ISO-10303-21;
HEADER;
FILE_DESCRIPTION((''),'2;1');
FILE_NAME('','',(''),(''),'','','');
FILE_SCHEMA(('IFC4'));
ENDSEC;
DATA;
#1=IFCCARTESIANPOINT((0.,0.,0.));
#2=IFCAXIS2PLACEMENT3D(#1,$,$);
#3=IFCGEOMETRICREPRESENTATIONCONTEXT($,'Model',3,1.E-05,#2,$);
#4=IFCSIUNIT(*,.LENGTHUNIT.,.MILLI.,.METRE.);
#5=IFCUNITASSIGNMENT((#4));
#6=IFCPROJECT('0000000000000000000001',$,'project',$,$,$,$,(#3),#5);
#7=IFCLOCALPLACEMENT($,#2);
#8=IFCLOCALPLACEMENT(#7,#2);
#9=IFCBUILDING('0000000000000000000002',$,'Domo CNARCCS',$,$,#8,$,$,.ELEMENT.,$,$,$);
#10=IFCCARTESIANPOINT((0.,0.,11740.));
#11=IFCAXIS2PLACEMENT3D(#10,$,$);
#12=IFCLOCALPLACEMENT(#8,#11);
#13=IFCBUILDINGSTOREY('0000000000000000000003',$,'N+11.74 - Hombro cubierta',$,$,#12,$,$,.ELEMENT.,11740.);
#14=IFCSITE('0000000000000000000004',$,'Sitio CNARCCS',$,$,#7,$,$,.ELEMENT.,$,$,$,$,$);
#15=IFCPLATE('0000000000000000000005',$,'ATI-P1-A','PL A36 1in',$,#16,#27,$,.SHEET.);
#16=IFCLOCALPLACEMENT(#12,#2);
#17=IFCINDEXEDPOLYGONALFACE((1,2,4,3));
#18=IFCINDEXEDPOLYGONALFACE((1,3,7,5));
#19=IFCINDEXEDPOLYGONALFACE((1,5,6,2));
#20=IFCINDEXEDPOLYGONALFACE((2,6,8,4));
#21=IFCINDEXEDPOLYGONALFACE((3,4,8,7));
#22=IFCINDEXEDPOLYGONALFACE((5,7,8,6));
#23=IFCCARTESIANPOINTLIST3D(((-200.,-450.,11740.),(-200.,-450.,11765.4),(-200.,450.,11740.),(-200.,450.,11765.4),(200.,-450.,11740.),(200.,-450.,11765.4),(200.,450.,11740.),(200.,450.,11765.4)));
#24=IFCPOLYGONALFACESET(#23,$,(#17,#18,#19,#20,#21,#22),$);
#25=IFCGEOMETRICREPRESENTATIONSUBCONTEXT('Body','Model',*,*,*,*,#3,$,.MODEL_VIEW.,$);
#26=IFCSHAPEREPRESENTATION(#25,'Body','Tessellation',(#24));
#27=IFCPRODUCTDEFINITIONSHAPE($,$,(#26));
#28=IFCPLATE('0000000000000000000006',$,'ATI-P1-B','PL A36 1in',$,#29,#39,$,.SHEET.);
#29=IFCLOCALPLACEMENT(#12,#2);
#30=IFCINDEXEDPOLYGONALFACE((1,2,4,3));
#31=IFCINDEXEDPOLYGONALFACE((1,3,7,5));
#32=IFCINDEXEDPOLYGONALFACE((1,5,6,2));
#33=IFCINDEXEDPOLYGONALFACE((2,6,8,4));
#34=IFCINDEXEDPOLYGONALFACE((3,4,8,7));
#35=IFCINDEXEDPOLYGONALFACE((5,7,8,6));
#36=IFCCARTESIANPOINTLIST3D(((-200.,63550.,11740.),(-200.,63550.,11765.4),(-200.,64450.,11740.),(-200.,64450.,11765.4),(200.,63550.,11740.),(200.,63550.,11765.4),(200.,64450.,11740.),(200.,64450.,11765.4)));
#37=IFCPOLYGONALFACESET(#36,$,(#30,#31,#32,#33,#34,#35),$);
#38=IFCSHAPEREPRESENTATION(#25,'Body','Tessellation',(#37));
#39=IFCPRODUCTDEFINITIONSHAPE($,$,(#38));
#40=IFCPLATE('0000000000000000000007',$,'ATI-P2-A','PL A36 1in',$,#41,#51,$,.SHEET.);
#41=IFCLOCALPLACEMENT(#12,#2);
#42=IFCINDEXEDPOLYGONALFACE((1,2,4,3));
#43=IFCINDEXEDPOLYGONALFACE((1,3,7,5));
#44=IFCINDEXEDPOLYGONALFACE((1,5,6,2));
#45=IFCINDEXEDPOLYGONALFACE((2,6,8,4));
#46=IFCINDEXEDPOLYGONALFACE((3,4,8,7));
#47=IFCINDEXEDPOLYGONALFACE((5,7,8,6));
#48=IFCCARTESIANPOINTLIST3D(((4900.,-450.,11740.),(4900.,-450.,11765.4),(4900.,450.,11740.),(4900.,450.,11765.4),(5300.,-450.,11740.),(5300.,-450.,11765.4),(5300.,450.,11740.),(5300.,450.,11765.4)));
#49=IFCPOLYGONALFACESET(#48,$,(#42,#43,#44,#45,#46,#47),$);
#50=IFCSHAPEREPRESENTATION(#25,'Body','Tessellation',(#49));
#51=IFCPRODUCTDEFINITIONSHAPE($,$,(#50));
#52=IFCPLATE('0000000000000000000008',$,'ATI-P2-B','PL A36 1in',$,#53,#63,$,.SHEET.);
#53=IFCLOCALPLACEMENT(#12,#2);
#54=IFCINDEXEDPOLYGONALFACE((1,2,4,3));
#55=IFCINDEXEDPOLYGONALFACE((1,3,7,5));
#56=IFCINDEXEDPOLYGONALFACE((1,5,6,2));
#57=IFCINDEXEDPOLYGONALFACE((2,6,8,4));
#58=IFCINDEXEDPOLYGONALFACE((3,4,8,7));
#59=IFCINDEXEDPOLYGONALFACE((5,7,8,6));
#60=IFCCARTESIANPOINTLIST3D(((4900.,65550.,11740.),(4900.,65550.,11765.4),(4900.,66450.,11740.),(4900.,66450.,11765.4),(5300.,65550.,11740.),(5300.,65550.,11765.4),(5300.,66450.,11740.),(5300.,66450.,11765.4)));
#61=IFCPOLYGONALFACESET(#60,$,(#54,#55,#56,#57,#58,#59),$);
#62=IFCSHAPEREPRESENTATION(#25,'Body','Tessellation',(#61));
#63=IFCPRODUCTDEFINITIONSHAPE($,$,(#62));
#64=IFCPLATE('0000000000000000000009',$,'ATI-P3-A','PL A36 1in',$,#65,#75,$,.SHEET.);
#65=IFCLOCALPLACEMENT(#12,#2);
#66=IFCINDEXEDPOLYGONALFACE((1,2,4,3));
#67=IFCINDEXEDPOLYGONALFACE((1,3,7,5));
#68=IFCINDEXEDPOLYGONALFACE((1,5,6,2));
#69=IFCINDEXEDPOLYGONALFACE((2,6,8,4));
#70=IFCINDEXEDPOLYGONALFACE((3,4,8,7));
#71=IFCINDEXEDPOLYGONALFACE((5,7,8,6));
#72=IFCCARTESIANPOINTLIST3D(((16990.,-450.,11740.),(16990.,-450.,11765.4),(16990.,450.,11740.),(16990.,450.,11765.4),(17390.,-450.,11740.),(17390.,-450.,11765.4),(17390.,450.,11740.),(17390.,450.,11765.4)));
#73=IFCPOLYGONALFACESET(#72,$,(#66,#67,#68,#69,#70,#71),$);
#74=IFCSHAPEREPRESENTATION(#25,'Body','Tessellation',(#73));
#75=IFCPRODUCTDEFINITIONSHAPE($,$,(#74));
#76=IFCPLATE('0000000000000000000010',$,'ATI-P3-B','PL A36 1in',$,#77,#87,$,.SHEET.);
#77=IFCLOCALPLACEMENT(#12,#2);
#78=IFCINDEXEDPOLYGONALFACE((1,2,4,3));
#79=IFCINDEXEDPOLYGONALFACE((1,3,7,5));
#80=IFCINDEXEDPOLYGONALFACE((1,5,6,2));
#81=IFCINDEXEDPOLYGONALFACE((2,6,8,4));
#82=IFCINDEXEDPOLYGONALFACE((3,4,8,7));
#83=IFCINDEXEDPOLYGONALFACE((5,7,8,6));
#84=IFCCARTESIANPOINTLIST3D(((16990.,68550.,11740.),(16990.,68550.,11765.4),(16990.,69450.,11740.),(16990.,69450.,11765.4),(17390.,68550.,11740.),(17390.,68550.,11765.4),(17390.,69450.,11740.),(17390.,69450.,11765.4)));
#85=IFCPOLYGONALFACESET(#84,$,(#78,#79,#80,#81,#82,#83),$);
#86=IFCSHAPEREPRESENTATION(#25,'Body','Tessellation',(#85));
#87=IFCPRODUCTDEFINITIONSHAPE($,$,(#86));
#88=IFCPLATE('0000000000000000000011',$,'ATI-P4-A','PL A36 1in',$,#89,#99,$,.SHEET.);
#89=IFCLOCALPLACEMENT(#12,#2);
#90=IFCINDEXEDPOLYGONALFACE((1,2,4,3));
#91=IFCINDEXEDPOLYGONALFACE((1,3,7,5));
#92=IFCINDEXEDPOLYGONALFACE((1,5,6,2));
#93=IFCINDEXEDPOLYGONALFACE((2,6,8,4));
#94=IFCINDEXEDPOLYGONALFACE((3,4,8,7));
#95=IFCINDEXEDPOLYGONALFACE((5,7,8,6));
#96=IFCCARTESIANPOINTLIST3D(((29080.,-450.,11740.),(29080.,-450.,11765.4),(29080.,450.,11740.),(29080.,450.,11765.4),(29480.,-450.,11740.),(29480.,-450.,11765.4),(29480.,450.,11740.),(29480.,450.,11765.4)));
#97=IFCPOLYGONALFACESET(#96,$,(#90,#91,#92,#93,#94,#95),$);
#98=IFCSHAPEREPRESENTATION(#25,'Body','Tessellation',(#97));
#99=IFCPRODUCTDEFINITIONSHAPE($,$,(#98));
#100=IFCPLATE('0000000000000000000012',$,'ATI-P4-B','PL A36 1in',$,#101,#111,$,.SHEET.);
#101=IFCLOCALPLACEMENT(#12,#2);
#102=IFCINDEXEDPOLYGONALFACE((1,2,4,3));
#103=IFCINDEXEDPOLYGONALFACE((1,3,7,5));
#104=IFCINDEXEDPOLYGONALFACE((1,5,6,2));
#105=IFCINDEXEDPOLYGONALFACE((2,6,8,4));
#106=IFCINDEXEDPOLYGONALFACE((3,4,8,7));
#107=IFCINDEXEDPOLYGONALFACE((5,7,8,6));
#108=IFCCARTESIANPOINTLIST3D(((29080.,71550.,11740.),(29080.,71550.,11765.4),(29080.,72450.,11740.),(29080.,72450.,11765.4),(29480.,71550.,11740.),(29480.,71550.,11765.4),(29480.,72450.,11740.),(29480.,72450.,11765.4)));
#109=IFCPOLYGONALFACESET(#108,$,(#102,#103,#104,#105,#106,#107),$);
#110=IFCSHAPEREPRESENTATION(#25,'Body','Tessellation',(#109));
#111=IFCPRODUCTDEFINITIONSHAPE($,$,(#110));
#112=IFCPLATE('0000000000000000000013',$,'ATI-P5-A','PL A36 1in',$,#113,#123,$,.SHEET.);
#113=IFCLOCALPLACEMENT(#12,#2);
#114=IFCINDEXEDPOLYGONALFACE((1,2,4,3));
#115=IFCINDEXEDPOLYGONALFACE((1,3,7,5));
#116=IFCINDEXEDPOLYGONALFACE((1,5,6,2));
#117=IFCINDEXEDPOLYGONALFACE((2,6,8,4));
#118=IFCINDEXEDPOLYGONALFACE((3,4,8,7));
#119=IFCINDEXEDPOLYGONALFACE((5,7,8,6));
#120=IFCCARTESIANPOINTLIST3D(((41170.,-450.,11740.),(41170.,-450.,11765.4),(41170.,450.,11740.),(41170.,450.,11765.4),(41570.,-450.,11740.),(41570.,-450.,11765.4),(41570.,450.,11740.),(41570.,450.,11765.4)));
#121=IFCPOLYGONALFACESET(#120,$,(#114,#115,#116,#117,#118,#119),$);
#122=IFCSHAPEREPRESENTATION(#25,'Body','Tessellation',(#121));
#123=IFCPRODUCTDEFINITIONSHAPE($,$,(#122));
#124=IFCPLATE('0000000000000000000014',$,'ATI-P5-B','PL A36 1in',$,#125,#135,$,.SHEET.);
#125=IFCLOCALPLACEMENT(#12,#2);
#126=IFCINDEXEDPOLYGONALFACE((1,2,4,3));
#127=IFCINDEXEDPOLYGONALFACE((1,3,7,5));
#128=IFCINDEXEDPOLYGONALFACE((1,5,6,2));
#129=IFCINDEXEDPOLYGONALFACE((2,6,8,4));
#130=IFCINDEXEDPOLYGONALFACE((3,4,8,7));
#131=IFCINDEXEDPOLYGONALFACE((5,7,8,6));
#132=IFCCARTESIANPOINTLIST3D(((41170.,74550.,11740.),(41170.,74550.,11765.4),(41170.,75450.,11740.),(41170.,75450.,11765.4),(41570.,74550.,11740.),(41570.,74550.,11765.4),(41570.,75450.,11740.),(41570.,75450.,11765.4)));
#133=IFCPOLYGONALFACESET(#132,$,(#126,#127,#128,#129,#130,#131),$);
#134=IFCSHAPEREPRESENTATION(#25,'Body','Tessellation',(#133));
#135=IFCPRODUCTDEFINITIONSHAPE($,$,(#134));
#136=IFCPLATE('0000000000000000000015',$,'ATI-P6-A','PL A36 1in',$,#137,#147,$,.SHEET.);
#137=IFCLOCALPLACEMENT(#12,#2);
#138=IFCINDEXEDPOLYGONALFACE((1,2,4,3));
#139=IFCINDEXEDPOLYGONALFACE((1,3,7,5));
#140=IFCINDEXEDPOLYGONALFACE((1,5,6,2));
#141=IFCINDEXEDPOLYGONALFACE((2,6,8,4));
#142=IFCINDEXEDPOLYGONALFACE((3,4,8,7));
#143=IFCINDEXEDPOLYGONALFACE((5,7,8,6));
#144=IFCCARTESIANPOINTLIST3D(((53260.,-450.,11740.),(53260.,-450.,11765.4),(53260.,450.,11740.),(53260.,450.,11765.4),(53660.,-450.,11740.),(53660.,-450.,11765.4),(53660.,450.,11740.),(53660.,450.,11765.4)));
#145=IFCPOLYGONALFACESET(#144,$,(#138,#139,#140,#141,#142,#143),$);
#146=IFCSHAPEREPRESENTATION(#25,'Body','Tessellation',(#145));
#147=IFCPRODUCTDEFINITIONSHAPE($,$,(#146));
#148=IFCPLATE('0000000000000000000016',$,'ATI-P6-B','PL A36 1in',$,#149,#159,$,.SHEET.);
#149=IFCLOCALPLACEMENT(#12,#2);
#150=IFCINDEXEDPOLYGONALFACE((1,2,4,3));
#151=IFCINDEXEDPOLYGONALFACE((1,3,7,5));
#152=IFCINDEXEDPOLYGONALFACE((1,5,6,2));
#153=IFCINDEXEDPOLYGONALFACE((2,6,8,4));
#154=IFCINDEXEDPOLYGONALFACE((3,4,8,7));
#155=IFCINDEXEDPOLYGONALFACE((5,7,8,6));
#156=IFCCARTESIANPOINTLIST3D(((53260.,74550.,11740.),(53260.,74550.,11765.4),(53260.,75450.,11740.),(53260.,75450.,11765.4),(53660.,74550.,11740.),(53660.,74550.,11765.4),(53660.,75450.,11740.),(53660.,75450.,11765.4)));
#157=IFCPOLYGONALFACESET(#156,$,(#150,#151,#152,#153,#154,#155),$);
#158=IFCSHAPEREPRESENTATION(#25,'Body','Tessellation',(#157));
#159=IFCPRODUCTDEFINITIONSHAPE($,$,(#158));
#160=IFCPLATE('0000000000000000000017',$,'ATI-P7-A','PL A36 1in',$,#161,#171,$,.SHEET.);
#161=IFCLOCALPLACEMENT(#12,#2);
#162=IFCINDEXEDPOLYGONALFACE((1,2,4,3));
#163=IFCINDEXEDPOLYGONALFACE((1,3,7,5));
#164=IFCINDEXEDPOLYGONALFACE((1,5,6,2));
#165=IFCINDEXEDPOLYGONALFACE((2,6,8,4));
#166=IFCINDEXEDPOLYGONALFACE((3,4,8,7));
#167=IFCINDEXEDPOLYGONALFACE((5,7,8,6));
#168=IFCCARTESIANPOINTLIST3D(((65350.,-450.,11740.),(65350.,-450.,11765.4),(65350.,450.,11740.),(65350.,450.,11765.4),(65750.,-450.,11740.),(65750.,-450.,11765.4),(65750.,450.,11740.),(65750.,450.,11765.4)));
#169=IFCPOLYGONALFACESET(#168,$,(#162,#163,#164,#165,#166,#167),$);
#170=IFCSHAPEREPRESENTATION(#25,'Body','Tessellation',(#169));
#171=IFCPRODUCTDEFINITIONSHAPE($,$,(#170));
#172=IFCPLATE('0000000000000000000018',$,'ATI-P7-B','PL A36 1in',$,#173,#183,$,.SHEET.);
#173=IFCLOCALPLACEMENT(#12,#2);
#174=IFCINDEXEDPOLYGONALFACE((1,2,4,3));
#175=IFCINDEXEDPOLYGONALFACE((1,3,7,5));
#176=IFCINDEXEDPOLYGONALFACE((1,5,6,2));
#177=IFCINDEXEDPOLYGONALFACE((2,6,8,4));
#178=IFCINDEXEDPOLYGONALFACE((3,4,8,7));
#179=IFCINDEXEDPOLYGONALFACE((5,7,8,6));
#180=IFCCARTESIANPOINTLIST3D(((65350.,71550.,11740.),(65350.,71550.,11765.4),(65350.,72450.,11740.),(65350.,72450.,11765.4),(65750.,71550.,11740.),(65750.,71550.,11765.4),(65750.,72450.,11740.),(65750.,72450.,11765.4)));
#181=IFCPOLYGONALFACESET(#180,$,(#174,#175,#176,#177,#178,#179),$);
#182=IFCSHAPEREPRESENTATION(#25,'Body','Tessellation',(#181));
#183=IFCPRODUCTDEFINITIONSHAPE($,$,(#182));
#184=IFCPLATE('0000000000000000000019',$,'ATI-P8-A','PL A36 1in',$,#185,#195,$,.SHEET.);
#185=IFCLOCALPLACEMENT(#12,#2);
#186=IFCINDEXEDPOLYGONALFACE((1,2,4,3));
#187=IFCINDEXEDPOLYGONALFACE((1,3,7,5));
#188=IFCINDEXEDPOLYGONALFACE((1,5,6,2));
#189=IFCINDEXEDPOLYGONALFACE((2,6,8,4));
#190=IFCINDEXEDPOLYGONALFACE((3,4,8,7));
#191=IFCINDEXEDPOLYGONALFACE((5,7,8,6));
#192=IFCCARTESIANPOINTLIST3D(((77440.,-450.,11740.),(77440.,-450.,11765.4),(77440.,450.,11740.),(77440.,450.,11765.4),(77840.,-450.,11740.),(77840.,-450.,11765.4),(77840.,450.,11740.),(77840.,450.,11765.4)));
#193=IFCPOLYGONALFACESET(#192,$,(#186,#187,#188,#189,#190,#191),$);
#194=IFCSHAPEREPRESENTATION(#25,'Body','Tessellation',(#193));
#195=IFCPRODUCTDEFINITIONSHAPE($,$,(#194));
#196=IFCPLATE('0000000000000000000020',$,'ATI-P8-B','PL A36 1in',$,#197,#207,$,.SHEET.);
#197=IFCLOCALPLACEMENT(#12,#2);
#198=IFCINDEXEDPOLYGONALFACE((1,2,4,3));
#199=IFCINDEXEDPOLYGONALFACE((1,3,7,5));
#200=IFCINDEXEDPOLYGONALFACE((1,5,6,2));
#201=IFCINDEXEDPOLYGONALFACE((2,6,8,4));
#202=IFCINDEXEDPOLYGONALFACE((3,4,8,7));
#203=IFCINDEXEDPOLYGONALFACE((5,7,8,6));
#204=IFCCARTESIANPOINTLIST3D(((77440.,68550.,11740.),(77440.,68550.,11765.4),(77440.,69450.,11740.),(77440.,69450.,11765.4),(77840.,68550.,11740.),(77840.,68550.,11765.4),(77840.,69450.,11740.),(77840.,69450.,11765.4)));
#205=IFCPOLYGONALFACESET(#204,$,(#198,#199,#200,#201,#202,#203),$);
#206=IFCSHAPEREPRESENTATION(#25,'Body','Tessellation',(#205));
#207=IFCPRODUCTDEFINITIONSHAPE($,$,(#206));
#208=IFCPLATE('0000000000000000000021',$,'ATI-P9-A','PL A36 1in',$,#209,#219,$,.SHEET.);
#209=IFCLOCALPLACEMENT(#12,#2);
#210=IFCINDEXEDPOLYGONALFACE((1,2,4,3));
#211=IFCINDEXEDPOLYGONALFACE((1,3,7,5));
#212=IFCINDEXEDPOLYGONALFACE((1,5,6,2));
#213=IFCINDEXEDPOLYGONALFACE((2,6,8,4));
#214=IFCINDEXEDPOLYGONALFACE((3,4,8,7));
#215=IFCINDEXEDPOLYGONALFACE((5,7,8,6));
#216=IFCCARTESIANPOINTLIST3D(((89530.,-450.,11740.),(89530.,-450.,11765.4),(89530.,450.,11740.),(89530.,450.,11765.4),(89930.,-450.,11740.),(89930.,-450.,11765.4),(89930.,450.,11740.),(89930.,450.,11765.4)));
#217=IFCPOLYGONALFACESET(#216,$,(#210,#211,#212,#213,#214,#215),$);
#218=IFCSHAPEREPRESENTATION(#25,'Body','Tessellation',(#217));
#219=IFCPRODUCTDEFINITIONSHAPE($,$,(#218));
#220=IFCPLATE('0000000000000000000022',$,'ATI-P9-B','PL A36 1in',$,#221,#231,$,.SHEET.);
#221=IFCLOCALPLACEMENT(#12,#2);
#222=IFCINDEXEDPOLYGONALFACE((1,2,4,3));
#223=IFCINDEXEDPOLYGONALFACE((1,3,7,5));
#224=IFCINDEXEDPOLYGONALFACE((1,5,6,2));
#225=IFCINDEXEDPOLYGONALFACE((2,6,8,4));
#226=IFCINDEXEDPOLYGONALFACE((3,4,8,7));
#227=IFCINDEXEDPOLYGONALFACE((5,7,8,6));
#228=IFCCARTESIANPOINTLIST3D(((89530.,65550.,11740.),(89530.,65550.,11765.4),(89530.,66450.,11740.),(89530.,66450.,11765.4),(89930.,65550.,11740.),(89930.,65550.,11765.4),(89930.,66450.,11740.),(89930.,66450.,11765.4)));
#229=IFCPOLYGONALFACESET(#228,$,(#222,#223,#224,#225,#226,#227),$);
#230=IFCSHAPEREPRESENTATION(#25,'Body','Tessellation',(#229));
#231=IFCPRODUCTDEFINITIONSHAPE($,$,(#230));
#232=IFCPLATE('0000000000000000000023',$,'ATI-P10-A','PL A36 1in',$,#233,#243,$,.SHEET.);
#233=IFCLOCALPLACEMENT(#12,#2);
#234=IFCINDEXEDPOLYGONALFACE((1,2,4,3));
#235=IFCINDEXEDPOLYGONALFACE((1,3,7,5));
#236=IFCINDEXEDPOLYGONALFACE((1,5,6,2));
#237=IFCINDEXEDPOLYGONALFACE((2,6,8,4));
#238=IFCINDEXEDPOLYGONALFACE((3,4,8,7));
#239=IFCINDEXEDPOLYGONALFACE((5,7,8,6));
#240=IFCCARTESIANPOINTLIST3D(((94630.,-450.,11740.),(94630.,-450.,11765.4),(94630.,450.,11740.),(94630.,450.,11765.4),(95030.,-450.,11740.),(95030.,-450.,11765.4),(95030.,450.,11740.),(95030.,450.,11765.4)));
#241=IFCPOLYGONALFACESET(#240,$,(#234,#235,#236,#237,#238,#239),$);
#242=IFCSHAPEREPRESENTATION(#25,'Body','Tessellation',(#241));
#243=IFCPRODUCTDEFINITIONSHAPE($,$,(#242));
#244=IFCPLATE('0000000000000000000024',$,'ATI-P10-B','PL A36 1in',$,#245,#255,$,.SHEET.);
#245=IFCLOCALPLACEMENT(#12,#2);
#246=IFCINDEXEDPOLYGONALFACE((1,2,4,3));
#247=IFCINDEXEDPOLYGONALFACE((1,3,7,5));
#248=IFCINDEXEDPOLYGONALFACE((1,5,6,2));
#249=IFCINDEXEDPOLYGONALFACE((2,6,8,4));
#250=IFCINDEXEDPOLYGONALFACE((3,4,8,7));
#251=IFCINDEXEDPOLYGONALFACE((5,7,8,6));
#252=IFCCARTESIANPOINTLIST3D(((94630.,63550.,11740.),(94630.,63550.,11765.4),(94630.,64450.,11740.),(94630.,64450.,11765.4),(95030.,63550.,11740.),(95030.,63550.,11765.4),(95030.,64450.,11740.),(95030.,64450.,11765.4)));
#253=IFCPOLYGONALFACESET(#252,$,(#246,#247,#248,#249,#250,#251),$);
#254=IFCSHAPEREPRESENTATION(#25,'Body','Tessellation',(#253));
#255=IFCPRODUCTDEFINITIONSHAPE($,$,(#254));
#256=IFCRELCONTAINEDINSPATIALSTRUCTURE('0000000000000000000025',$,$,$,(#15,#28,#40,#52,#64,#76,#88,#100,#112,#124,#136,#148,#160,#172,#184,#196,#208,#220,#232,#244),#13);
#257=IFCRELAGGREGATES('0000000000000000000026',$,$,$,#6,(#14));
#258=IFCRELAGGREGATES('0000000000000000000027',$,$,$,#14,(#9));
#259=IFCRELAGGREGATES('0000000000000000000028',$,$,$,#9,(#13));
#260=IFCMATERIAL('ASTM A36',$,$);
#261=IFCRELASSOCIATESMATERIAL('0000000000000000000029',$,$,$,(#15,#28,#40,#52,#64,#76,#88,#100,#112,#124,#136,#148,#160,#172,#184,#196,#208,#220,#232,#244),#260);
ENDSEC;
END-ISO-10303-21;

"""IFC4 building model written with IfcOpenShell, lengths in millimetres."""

from ifc_helpers import new_model, si_unit, frame, origin, place, context, subcontext, project, spatial, polyline, outline, extrude, material, element, save


model = new_model("IFC4")

# Units and contexts
model_context = context("Model", 3, precision=1e-05, world=origin())
body_context = subcontext(model_context, "Body", "Model", "MODEL_VIEW")
ifc_project = project(units=[si_unit("LENGTHUNIT", "METRE", prefix="MILLI")], contexts=[model_context])

# Site, building, storey
site_placement = place(None, origin())
site = spatial("IfcSite", under=ifc_project, at=site_placement, Name="Sitio CNARCCS", CompositionType="ELEMENT")
building_placement = place(site_placement, origin())
building = spatial("IfcBuilding", under=site, at=building_placement, Name="Domo CNARCCS", CompositionType="ELEMENT")
storey_placement = place(building_placement, frame((0.0, 0.0, 11740.0)))
storey = spatial("IfcBuildingStorey", under=building, at=storey_placement, Name="N+11.74 - Hombro cubierta", CompositionType="ELEMENT", Elevation=11740.0)

# Plates
ifc_material = material(Name="ASTM A36")
for number, where, name in (
    (1, (0.0, 0.0, 11740.0), "ATI-P1-A"),
    (2, (0.0, 64000.0, 11740.0), "ATI-P1-B"),
    (3, (5100.0, 0.0, 11740.0), "ATI-P2-A"),
    (4, (5100.0, 66000.0, 11740.0), "ATI-P2-B"),
    (5, (17190.0, 0.0, 11740.0), "ATI-P3-A"),
    (6, (17190.0, 69000.0, 11740.0), "ATI-P3-B"),
    (7, (29280.0, 0.0, 11740.0), "ATI-P4-A"),
    (8, (29280.0, 72000.0, 11740.0), "ATI-P4-B"),
    (9, (41370.0, 0.0, 11740.0), "ATI-P5-A"),
    (10, (41370.0, 75000.0, 11740.0), "ATI-P5-B"),
    (11, (53460.0, 0.0, 11740.0), "ATI-P6-A"),
    (12, (53460.0, 75000.0, 11740.0), "ATI-P6-B"),
    (13, (65550.0, 0.0, 11740.0), "ATI-P7-A"),
    (14, (65550.0, 72000.0, 11740.0), "ATI-P7-B"),
    (15, (77640.0, 0.0, 11740.0), "ATI-P8-A"),
    (16, (77640.0, 69000.0, 11740.0), "ATI-P8-B"),
    (17, (89730.0, 0.0, 11740.0), "ATI-P9-A"),
    (18, (89730.0, 66000.0, 11740.0), "ATI-P9-B"),
    (19, (94830.0, 0.0, 11740.0), "ATI-P10-A"),
    (20, (94830.0, 64000.0, 11740.0), "ATI-P10-B"),
):
    element("IfcPlate", number, at=place(storey_placement, frame(where)), inside=storey, material=ifc_material, Name=name, Description="PL A36 1in", PredefinedType="SHEET", context=body_context, shape_type="SweptSolid", body=[
        extrude(outline(polyline([(-200.0, -450.0), (200.0, -450.0), (200.0, 450.0), (-200.0, 450.0), (-200.0, -450.0)])), origin(), (0.0, 0.0, 1.0), 25.4),
    ])

save(model, "model.ifc")
